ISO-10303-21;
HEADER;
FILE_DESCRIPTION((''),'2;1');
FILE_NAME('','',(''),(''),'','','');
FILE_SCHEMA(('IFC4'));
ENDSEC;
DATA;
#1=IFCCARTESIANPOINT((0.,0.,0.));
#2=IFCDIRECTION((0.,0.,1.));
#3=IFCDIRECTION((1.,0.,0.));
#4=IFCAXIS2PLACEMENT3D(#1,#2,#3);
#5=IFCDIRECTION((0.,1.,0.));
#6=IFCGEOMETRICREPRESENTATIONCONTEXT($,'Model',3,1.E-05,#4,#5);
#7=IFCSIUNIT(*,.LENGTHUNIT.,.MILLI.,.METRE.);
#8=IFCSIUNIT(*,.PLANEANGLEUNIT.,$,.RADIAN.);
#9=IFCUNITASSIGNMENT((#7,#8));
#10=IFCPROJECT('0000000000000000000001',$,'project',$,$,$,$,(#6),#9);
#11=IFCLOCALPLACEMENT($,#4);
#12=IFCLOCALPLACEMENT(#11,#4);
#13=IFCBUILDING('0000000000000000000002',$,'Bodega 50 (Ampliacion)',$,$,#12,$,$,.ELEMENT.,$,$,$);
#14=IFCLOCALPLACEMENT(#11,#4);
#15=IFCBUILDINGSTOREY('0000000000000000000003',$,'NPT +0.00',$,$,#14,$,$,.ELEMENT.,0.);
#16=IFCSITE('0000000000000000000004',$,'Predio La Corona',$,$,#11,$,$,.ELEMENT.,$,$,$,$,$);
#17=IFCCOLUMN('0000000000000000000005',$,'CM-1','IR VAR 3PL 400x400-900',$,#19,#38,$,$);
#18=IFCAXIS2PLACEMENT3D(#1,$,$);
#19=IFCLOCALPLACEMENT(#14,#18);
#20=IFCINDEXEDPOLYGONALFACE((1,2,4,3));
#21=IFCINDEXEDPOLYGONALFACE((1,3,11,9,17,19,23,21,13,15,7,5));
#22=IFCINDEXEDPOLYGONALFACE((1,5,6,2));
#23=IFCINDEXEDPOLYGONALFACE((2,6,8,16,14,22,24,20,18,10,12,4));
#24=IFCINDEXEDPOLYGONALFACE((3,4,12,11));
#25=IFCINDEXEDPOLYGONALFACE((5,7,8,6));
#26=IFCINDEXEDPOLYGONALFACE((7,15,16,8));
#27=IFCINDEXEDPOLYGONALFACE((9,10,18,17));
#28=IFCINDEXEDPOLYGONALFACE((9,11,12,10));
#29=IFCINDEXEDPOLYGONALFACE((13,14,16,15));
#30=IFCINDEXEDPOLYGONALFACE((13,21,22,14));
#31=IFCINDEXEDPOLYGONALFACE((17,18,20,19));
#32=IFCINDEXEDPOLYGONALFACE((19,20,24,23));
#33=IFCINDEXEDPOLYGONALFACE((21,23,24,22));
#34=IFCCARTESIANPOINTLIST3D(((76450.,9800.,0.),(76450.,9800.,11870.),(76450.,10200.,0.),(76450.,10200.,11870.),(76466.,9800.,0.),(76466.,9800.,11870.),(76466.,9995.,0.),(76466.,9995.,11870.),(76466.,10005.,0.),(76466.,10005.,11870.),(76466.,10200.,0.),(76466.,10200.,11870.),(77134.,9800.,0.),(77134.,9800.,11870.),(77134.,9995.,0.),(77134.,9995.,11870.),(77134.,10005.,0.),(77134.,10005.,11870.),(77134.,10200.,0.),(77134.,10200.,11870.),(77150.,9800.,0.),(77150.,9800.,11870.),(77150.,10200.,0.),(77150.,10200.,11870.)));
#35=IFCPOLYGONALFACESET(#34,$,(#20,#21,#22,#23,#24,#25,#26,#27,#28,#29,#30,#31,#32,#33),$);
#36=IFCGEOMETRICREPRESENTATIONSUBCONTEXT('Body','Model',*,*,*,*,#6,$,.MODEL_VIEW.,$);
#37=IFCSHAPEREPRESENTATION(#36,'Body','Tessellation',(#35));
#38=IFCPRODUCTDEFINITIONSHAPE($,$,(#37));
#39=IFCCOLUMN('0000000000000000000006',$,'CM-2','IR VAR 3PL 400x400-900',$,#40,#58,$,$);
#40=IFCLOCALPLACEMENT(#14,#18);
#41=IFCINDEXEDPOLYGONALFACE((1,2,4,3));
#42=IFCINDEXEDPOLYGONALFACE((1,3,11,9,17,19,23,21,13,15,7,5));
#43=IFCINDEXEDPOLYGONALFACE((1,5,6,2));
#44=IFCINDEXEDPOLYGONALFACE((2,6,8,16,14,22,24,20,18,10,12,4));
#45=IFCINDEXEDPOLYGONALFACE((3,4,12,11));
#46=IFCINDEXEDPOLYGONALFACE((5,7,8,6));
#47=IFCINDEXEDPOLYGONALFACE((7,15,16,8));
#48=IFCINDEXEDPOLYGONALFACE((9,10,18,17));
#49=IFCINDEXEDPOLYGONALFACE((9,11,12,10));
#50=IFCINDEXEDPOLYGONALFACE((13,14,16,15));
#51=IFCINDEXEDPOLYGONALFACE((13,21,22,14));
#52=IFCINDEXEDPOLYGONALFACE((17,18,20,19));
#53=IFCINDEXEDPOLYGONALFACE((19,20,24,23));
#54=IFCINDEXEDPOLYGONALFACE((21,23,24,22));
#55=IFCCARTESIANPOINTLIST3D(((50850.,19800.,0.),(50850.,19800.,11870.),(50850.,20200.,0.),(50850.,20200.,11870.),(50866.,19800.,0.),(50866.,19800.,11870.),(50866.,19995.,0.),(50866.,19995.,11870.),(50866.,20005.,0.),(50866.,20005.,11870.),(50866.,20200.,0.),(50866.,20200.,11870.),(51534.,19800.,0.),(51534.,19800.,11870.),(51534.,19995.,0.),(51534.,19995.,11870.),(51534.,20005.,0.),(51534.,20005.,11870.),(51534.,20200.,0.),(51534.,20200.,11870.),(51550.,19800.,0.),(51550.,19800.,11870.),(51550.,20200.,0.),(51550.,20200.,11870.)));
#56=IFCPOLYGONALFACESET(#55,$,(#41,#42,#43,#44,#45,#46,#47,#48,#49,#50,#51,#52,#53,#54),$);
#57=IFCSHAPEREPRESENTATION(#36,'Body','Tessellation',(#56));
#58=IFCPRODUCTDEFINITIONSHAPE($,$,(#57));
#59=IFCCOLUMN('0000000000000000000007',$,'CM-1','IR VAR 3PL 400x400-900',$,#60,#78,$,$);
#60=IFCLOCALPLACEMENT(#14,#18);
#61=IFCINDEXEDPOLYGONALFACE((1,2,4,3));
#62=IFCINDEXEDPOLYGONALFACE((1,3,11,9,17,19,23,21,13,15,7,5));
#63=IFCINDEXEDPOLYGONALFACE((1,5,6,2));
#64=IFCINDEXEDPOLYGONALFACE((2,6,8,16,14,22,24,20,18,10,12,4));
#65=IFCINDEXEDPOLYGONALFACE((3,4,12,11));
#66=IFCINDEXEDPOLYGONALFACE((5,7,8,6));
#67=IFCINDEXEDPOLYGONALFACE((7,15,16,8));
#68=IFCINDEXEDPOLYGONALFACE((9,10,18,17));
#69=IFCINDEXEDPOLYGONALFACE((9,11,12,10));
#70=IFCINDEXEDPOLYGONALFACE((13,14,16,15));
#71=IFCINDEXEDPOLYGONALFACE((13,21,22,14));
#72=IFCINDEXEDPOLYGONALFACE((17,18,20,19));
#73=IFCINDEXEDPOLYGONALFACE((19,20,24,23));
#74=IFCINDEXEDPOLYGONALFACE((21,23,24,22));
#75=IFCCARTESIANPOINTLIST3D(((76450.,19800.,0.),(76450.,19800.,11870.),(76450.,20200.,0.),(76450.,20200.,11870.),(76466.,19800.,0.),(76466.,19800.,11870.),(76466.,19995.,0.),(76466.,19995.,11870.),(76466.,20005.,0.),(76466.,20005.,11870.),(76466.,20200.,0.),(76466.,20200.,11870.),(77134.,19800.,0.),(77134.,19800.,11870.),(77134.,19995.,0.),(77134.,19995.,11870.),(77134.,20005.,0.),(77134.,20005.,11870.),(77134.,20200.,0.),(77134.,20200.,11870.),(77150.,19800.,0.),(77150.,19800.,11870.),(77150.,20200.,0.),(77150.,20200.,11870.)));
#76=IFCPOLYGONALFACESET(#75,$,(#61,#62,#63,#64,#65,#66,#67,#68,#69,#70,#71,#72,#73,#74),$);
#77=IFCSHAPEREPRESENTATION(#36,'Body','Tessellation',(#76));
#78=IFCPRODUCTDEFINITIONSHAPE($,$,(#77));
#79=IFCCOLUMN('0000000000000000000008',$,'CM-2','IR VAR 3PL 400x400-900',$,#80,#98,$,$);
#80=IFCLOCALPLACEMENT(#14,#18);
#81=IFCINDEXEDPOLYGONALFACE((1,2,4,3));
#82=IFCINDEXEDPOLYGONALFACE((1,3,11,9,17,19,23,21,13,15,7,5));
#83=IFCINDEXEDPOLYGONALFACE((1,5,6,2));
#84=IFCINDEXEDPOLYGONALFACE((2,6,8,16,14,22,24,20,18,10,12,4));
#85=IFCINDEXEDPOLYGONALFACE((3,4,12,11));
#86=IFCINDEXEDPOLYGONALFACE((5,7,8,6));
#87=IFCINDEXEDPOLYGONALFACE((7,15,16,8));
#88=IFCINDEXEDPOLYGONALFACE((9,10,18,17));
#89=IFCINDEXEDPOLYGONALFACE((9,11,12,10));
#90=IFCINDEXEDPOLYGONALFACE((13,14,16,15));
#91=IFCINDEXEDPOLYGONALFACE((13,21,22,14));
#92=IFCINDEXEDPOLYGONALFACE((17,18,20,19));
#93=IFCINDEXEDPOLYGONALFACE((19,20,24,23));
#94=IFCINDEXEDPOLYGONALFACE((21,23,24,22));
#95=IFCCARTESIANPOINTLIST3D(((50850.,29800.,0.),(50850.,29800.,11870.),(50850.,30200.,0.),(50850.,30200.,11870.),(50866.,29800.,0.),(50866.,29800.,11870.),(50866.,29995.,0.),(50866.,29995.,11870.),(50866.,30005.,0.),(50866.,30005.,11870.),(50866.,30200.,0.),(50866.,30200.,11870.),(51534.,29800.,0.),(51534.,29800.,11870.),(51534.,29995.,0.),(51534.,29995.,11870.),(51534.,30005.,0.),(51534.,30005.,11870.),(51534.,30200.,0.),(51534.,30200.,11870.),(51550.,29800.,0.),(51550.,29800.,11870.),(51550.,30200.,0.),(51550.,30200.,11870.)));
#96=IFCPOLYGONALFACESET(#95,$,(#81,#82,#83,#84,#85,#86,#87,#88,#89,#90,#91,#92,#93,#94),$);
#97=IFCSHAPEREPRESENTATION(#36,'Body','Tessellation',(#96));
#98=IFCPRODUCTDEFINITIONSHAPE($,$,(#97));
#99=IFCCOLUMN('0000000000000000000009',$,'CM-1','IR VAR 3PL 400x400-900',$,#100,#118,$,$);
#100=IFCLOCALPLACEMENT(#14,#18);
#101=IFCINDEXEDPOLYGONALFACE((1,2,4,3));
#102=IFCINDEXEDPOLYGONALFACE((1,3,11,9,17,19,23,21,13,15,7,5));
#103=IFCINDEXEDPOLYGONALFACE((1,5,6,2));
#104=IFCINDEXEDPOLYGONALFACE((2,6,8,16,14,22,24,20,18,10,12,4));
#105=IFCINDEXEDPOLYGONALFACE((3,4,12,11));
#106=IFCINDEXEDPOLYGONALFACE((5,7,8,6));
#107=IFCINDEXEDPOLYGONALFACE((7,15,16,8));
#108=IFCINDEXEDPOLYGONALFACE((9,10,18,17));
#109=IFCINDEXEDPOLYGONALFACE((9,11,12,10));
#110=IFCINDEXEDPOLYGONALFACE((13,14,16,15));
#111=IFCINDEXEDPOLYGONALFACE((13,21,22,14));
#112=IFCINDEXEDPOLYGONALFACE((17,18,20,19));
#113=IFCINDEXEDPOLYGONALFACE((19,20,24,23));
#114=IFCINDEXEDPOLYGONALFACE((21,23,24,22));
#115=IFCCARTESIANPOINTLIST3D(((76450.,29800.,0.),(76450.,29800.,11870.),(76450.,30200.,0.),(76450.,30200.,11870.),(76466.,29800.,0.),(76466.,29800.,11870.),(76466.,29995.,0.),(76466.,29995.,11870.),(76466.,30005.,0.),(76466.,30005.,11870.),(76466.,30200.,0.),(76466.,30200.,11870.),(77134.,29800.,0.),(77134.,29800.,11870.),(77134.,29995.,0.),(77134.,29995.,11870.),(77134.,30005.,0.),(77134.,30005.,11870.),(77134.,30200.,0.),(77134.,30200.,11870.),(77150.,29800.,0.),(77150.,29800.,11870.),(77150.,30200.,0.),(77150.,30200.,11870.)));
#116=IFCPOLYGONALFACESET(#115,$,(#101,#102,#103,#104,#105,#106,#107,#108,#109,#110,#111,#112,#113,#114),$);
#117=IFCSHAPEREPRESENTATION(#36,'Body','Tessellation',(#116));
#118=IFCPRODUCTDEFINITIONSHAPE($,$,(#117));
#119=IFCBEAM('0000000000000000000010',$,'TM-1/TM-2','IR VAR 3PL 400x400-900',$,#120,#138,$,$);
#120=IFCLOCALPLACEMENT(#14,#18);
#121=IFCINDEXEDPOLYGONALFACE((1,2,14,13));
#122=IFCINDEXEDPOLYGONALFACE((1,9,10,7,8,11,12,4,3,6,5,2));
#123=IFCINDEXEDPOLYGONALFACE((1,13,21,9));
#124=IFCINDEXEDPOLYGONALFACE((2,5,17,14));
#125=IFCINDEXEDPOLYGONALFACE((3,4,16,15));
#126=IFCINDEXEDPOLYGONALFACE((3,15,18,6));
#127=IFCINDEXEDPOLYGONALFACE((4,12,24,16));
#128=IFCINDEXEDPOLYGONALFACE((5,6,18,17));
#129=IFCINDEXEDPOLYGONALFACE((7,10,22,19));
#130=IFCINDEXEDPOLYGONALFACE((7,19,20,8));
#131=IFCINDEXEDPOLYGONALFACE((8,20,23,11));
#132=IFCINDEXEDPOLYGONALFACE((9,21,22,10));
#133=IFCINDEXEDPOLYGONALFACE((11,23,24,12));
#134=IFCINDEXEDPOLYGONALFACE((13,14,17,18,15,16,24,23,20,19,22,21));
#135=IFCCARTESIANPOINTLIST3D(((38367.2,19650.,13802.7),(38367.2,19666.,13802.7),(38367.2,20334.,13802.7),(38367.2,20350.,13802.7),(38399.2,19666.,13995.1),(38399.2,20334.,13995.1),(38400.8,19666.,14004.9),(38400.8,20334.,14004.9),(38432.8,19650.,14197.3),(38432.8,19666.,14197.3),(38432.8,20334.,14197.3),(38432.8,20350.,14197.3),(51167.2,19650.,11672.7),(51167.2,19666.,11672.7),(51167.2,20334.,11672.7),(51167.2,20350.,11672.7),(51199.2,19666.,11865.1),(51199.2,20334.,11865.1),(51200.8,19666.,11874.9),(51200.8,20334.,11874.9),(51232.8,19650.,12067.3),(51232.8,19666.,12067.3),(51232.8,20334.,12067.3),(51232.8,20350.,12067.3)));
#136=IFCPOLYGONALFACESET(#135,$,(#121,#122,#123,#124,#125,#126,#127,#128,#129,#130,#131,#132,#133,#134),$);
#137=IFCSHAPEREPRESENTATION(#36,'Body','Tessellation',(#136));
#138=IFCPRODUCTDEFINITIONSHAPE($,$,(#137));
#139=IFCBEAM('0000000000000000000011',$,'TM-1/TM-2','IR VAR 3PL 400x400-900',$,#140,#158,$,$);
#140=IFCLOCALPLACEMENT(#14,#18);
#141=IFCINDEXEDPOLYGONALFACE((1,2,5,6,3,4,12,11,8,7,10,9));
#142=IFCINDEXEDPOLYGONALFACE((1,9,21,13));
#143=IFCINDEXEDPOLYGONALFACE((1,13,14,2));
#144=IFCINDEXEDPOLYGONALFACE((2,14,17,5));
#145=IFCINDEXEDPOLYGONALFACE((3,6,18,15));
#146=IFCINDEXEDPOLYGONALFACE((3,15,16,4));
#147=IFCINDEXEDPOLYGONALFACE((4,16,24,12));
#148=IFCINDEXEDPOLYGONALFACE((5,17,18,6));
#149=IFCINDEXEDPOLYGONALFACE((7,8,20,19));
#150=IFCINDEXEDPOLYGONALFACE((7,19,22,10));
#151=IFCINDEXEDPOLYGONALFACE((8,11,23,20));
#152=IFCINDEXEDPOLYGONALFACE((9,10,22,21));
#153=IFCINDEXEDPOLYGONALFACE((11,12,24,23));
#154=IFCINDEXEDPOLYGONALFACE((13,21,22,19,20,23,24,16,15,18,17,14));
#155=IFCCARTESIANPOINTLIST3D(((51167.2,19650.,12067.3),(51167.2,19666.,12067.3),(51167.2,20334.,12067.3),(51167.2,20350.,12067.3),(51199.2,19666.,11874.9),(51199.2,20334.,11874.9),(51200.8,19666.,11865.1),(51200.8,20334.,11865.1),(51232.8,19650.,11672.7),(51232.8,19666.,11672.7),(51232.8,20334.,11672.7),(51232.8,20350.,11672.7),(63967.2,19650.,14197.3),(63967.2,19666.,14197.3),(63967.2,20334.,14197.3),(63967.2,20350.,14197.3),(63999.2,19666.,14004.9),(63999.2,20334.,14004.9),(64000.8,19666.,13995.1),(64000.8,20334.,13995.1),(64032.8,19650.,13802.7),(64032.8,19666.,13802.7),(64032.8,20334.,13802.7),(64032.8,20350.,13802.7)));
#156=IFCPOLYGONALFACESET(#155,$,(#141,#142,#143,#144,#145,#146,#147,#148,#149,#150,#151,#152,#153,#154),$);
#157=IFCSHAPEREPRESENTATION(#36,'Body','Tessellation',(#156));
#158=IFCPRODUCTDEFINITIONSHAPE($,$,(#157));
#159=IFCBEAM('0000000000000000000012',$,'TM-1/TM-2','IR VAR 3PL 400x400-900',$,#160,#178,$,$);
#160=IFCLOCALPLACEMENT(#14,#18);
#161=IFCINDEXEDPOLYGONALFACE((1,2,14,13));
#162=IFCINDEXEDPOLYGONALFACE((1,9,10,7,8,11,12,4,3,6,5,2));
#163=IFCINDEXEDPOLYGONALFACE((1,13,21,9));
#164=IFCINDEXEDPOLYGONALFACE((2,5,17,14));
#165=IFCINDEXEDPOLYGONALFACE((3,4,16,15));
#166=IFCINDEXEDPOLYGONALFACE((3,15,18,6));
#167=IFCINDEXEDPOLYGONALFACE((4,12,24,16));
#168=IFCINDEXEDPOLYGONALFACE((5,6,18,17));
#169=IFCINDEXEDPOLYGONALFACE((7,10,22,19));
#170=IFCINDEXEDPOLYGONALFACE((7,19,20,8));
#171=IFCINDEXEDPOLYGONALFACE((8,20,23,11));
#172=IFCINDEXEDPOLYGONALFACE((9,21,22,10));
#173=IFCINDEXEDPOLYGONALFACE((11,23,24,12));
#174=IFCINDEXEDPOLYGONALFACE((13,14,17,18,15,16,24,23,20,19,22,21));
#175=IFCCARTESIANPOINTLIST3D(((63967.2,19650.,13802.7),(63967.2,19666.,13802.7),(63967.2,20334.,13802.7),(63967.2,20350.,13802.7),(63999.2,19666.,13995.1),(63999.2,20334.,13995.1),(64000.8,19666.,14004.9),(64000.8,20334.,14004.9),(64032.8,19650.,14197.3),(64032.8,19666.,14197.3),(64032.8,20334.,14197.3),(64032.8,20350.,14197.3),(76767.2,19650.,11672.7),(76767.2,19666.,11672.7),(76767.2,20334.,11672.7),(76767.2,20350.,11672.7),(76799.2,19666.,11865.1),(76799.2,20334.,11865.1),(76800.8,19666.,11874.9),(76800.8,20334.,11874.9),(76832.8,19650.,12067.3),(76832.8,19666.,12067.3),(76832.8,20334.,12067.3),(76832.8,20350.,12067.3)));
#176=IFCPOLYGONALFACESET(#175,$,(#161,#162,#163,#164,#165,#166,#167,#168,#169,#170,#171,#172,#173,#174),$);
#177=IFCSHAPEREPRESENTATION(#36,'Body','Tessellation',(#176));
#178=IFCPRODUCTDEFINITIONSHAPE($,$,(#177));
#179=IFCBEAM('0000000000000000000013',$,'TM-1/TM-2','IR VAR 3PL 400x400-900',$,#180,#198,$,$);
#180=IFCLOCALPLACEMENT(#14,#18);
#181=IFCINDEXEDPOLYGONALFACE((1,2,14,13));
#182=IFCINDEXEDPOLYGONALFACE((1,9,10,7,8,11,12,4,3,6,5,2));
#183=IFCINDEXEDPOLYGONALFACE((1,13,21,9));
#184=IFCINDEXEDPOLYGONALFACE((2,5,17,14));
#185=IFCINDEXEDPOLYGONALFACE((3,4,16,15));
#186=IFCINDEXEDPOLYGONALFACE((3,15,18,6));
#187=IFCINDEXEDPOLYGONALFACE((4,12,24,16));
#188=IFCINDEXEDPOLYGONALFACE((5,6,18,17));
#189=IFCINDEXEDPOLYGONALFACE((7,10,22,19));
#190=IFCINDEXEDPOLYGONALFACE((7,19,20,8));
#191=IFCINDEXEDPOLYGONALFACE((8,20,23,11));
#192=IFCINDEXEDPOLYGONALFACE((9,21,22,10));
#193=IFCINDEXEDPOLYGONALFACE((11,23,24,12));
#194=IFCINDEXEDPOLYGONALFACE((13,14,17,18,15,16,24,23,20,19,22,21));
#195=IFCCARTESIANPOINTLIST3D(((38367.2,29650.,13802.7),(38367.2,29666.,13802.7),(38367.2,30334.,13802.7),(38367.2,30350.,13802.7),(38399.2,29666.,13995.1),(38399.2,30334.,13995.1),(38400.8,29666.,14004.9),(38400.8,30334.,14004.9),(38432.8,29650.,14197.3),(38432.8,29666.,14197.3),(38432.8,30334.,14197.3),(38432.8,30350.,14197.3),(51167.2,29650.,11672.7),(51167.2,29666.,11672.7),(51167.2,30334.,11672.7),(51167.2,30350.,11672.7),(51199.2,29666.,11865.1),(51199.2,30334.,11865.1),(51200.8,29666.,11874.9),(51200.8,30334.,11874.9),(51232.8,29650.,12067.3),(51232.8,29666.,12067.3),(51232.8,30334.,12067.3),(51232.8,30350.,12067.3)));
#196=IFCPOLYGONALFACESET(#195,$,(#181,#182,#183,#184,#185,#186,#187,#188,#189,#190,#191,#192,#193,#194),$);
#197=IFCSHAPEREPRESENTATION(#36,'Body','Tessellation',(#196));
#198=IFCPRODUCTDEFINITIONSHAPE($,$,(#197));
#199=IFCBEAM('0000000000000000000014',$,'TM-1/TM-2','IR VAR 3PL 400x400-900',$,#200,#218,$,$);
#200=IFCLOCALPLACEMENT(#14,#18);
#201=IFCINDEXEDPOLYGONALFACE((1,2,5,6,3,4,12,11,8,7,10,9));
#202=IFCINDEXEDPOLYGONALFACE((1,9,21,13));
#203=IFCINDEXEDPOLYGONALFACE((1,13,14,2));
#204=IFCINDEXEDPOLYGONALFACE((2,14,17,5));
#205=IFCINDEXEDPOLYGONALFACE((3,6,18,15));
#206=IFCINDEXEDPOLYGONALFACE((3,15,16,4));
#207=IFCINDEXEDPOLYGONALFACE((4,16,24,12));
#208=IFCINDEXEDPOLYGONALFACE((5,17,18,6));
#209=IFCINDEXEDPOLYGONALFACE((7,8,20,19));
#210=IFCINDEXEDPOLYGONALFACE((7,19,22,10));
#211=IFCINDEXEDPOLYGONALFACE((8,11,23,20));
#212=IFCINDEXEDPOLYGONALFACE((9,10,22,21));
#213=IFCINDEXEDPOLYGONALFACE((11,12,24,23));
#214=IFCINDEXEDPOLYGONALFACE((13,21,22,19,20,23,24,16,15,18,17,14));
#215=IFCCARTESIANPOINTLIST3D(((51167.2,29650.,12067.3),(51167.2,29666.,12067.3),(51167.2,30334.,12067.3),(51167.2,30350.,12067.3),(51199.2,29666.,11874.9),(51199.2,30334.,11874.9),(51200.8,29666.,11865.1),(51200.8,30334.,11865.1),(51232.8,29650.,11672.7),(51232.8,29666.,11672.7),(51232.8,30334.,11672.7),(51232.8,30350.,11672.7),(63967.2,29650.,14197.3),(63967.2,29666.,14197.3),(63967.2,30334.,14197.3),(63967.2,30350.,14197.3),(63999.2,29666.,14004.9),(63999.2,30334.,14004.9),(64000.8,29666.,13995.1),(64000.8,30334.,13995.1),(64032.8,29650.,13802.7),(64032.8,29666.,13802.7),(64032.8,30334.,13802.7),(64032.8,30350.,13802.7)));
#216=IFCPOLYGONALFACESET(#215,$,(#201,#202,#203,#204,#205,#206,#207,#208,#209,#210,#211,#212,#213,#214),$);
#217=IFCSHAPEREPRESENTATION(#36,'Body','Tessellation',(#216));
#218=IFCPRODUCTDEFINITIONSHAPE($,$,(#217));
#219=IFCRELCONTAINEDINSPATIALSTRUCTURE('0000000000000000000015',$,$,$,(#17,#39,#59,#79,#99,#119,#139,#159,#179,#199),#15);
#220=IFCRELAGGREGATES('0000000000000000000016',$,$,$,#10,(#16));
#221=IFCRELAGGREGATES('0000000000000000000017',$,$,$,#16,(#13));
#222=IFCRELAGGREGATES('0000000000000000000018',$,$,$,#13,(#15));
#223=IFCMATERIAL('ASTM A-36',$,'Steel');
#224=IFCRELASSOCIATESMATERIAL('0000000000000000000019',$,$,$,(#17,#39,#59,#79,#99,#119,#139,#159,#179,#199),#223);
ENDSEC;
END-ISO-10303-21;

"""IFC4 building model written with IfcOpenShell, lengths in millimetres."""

from ifc_helpers import new_model, si_unit, direction, frame, origin_with_axes, origin_2d, place, context, subcontext, project, spatial, i_section, extrude, material, element, save


model = new_model("IFC4")

# Units and contexts
model_context = context("Model", 3, precision=1e-05, world=origin_with_axes(), true_north=direction((0.0, 1.0, 0.0)))
body_context = subcontext(model_context, "Body", "Model", "MODEL_VIEW")
ifc_project = project(units=[si_unit("LENGTHUNIT", "METRE", prefix="MILLI"), si_unit("PLANEANGLEUNIT", "RADIAN")], contexts=[model_context])

# Site, building, storey
site_placement = place(None, origin_with_axes())
site = spatial("IfcSite", under=ifc_project, at=site_placement, Name="Predio La Corona", CompositionType="ELEMENT")
building_placement = place(site_placement, origin_with_axes())
building = spatial("IfcBuilding", under=site, at=building_placement, Name="Bodega 50 (Ampliacion)", CompositionType="ELEMENT")
storey_placement = place(site_placement, origin_with_axes())
storey = spatial("IfcBuildingStorey", under=building, at=storey_placement, Name="NPT +0.00", CompositionType="ELEMENT", Elevation=0.0)

# Columns
ifc_material = material(Name="ASTM A-36", Category="Steel")
for number, where, z_axis, x_axis, name in (
    (1, (76800.0, 10000.0, 0.0), (0.0, 0.0, 1.0), (0.0, -1.0, 0.0), "CM-1"),
    (2, (51200.0, 20000.0, 0.0), (0.0, 0.0, 1.0), (0.0, -1.0, 0.0), "CM-2"),
    (3, (76800.0, 20000.0, 0.0), (0.0, 0.0, 1.0), (0.0, -1.0, 0.0), "CM-1"),
    (4, (51200.0, 30000.0, 0.0), (0.0, 0.0, 1.0), (0.0, -1.0, 0.0), "CM-2"),
    (5, (76800.0, 30000.0, 0.0), (0.0, 0.0, 1.0), (0.0, -1.0, 0.0), "CM-1"),
):
    element("IfcColumn", number, at=place(storey_placement, frame(where, z_axis=z_axis, x_axis=x_axis)), inside=storey, material=ifc_material, Name=name, Description="IR VAR 3PL 400x400-900", context=body_context, shape_type="SweptSolid", body=[
        extrude(i_section(OverallWidth=400.0, OverallDepth=700.0, WebThickness=10.0, FlangeThickness=16.0, at=origin_2d()), origin_with_axes(), (0.0, 0.0, 1.0), 11870.0),
    ])

# Beams
for number, where, z_axis, x_axis, name in (
    (6, (38400.0, 20000.0, 14000.0), (0.986436, 0.0, -0.164149), (-0.164149, 0.0, -0.986436), "TM-1/TM-2"),
    (7, (51200.0, 20000.0, 11870.0), (0.986436, 0.0, 0.164149), (0.164149, 0.0, -0.986436), "TM-1/TM-2"),
    (8, (64000.0, 20000.0, 14000.0), (0.986436, 0.0, -0.164149), (-0.164149, 0.0, -0.986436), "TM-1/TM-2"),
    (9, (38400.0, 30000.0, 14000.0), (0.986436, 0.0, -0.164149), (-0.164149, 0.0, -0.986436), "TM-1/TM-2"),
    (10, (51200.0, 30000.0, 11870.0), (0.986436, 0.0, 0.164149), (0.164149, 0.0, -0.986436), "TM-1/TM-2"),
):
    element("IfcBeam", number, at=place(storey_placement, frame(where, z_axis=z_axis, x_axis=x_axis)), inside=storey, material=ifc_material, Name=name, Description="IR VAR 3PL 400x400-900", context=body_context, shape_type="SweptSolid", body=[
        extrude(i_section(OverallWidth=400.0, OverallDepth=700.0, WebThickness=10.0, FlangeThickness=16.0, at=origin_2d()), origin_with_axes(), (0.0, 0.0, 1.0), 12976.0),
    ])

save(model, "model.ifc")
